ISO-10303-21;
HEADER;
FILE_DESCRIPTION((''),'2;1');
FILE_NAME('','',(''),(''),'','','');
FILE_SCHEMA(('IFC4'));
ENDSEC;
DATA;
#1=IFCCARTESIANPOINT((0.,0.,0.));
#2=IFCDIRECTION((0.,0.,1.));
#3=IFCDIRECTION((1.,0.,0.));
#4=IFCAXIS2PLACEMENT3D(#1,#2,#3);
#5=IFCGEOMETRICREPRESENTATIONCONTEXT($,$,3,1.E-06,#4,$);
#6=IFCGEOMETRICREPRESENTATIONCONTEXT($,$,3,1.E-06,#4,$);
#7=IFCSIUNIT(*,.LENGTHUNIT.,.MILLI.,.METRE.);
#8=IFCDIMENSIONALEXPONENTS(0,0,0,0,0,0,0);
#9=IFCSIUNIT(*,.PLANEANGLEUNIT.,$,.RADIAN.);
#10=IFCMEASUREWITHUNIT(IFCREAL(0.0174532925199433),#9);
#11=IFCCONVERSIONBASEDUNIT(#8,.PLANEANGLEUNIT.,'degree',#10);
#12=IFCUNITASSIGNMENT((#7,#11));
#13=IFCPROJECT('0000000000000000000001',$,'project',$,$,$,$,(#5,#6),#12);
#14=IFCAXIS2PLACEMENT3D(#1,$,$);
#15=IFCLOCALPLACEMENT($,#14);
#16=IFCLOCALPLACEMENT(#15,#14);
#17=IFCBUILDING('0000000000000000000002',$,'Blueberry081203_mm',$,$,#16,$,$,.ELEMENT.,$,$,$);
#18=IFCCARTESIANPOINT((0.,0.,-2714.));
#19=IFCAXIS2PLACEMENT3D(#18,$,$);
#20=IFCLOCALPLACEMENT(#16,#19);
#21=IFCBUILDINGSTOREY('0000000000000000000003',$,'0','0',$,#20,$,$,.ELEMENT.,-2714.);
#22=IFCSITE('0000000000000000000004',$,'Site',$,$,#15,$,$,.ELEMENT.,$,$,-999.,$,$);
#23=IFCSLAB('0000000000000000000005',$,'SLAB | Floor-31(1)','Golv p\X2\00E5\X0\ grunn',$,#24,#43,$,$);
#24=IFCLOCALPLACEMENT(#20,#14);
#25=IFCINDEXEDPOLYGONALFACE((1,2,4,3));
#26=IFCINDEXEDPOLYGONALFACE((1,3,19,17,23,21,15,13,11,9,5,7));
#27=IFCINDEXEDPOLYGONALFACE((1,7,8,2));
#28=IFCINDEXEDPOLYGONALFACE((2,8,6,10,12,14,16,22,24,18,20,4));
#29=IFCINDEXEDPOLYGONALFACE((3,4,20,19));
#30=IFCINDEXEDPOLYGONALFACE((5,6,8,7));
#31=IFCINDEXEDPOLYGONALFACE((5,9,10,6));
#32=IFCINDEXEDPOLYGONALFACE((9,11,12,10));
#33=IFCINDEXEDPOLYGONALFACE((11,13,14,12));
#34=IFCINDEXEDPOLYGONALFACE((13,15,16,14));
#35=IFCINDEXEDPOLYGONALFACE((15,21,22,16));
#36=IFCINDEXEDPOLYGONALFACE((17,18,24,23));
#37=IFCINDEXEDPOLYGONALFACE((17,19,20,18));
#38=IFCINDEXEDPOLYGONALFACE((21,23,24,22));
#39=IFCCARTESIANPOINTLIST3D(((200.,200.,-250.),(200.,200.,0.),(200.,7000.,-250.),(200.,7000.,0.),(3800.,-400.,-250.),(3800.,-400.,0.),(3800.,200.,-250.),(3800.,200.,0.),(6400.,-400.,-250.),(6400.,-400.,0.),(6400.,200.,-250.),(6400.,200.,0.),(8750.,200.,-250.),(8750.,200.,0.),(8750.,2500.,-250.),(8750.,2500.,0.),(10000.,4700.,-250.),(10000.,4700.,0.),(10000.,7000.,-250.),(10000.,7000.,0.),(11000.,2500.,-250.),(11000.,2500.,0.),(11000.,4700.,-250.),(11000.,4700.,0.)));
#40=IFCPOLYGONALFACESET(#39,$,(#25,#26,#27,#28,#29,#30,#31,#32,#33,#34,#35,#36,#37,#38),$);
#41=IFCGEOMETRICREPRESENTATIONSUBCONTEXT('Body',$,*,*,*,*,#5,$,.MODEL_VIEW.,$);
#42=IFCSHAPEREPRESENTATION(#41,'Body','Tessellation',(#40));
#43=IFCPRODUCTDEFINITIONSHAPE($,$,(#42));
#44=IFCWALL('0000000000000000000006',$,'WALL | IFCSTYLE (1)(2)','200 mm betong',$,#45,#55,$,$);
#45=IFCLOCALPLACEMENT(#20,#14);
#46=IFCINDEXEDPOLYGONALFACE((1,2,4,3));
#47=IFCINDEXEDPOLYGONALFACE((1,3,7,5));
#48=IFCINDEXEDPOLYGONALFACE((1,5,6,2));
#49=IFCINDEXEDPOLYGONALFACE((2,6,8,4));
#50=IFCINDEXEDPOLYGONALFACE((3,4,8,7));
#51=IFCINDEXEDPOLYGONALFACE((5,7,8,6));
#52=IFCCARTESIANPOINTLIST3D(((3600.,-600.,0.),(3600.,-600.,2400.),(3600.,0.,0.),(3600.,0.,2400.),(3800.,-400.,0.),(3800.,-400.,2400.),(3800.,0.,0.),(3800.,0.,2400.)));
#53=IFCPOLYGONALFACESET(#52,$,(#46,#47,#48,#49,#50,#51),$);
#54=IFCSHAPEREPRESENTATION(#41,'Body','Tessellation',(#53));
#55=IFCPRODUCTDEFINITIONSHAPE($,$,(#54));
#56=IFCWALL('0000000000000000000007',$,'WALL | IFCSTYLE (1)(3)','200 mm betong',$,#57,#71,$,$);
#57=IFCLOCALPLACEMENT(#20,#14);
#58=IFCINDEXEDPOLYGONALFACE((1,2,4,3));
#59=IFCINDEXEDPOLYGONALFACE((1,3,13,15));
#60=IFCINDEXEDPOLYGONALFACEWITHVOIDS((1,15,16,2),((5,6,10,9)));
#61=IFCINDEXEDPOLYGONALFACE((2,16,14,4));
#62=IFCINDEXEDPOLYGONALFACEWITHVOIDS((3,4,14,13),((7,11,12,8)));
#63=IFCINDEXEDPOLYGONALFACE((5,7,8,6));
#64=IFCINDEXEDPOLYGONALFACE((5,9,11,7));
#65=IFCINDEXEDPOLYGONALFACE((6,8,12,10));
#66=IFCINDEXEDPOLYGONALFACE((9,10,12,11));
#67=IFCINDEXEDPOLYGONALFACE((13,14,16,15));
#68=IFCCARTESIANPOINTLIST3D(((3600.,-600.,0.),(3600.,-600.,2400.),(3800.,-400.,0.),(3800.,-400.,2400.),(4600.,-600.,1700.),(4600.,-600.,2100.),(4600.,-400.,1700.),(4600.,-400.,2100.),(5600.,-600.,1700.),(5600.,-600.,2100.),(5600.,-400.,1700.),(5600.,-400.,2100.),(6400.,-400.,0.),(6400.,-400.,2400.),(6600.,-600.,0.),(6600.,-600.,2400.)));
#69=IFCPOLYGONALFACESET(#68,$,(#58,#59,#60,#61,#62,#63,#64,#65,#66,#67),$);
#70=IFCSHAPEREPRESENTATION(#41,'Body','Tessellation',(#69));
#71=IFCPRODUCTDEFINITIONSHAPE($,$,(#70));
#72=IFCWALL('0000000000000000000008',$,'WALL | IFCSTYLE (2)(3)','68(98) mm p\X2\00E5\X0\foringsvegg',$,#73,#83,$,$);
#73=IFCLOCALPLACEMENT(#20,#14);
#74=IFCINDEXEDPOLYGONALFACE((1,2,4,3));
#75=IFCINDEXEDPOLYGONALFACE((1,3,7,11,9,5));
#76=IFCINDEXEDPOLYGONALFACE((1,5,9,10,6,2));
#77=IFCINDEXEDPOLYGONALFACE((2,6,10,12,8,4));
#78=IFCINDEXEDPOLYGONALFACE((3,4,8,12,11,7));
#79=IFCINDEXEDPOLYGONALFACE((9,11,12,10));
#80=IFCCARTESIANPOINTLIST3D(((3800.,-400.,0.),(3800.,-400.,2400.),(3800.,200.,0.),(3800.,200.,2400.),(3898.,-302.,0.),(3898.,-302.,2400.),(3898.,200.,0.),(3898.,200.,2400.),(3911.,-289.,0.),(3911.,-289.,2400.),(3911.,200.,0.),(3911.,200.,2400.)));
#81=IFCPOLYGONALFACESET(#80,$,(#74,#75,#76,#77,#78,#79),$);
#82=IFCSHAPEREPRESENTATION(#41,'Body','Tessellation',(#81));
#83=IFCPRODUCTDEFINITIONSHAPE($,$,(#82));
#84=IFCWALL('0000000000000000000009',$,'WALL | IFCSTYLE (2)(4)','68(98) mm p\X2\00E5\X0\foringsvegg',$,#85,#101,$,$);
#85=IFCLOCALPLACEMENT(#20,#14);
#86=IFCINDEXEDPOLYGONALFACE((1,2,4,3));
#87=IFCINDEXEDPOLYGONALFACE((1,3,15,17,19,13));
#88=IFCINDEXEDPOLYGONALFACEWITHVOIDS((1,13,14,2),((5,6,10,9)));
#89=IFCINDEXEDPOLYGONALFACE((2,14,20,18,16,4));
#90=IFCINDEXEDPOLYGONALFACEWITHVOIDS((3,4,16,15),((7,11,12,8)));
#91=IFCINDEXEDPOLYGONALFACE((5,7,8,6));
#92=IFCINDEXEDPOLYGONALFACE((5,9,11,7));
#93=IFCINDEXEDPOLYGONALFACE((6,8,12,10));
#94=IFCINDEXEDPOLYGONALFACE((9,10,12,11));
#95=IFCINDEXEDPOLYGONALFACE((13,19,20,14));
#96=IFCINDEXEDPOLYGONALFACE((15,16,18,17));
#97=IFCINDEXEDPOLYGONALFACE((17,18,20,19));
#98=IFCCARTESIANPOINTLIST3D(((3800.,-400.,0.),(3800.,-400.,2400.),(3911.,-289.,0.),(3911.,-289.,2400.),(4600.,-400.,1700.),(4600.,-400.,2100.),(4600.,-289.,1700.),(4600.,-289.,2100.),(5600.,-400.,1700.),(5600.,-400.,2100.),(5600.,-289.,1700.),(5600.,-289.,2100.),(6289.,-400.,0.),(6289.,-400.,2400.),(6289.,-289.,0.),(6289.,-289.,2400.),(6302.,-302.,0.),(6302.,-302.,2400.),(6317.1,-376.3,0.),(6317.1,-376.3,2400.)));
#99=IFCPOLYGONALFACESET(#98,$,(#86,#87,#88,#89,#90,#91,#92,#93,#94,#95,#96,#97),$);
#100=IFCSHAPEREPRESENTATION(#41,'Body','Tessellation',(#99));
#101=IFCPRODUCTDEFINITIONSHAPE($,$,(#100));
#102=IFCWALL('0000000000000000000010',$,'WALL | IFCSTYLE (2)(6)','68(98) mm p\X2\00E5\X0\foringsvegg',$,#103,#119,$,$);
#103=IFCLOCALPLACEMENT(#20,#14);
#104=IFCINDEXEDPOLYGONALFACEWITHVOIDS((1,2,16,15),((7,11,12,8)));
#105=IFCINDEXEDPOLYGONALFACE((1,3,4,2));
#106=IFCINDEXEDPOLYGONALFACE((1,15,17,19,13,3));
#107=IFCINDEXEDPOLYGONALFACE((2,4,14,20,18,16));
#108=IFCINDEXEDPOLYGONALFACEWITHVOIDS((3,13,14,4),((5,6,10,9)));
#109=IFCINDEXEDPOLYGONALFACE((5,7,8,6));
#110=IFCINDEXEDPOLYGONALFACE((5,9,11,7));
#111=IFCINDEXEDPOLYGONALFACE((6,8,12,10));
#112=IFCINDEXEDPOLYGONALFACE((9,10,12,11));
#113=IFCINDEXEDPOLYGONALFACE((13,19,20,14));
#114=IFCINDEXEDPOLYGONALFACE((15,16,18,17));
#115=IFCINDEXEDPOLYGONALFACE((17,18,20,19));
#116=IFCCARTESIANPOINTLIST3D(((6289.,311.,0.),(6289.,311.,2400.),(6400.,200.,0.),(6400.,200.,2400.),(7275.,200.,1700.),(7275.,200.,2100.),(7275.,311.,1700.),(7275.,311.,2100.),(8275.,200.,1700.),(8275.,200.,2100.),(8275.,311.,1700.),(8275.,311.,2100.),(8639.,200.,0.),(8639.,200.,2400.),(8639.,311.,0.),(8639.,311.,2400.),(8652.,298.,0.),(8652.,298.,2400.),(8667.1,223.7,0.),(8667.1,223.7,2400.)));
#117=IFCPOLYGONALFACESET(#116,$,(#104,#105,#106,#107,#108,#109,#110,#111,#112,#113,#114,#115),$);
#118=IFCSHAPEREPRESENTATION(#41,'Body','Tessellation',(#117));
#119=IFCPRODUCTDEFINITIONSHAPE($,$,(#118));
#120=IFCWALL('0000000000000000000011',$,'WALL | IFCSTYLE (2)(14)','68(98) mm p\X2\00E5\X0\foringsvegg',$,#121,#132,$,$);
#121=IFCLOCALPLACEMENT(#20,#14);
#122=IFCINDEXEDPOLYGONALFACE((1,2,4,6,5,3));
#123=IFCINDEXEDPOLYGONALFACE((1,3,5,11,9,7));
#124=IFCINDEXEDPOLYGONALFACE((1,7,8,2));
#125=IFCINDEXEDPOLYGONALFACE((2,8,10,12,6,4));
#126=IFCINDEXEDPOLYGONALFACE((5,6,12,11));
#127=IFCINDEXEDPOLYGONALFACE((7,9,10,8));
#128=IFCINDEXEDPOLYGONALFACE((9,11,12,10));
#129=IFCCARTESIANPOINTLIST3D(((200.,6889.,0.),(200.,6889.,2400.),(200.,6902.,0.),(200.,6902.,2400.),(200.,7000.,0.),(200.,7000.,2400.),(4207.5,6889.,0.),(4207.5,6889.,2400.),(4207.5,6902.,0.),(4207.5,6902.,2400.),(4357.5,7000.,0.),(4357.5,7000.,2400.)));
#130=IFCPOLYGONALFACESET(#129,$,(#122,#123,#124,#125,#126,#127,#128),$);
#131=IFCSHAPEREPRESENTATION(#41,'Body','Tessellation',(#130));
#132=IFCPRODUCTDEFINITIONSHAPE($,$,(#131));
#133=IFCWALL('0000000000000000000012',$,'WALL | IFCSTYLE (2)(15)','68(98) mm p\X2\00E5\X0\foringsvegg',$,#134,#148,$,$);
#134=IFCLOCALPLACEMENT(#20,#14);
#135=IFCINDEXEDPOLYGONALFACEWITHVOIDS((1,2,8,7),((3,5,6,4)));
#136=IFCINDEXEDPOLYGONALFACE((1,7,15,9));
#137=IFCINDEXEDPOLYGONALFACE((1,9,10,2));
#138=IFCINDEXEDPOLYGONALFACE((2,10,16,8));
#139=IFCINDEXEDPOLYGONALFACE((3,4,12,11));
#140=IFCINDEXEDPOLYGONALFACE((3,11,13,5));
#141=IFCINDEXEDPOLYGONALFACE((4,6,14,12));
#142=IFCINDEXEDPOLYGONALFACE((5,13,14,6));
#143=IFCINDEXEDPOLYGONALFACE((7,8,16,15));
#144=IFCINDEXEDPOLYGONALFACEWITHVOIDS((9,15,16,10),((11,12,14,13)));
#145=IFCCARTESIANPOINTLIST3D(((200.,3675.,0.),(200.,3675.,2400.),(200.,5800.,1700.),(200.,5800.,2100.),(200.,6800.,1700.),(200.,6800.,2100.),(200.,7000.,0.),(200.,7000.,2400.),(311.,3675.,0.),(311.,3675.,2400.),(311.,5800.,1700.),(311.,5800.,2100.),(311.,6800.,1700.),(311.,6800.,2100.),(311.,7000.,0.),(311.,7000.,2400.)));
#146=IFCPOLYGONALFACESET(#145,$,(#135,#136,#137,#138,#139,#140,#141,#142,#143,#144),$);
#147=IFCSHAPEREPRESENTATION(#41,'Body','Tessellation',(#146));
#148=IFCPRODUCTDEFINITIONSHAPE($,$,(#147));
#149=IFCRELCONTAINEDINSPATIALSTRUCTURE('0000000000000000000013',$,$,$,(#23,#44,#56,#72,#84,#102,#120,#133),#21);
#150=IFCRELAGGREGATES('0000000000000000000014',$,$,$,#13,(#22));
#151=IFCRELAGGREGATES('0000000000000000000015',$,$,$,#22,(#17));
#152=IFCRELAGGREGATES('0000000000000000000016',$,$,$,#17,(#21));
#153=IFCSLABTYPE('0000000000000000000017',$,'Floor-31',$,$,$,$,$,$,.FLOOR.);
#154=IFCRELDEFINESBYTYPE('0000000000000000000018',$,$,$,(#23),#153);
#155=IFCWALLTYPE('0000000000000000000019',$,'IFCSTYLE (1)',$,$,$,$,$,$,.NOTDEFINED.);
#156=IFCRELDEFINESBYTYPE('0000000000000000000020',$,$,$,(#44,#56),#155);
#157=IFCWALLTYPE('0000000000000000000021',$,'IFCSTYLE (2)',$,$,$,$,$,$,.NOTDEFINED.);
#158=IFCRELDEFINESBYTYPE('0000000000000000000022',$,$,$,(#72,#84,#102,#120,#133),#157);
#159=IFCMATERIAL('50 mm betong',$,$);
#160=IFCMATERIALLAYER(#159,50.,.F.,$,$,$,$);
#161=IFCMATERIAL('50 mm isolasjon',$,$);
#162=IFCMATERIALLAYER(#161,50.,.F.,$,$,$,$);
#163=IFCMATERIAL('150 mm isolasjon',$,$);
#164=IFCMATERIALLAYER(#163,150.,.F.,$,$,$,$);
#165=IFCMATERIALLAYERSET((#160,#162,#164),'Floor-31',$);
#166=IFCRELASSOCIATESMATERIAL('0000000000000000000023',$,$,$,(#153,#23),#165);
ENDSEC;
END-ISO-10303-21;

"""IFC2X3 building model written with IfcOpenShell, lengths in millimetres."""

from ifc_helpers import new_model, entity, si_unit, converted_unit, frame, origin, origin_with_axes, origin_2d_with_axis, place, context, subcontext, project, spatial, polyline, segment, composite_curve, rectangle, outline, extrude, material, layer, layer_set, layer_usage, type_object, element, save


model = new_model("IFC2X3")

# Units and contexts
context_of_model_1 = context(None, 3, precision=1e-06, world=origin_with_axes())
context_of_model_2 = context(None, 3, precision=1e-06, world=origin_with_axes())
body_context = subcontext(context_of_model_1, "Body", None, "MODEL_VIEW")
ifc_project = project(units=[si_unit("LENGTHUNIT", "METRE", prefix="MILLI"), converted_unit("PLANEANGLEUNIT", "degree", entity("IfcReal", 0.0174532925199433), si_unit("PLANEANGLEUNIT", "RADIAN"), dimensions=[0, 0, 0, 0, 0, 0, 0])], contexts=[context_of_model_1, context_of_model_2])

# Site, building, storey
site_placement = place(None, origin())
site = spatial("IfcSite", under=ifc_project, at=site_placement, Name="Site", CompositionType="ELEMENT", RefElevation=-999.0)
building_placement = place(site_placement, origin())
building = spatial("IfcBuilding", under=site, at=building_placement, Name="Blueberry081203_mm", CompositionType="ELEMENT")
storey_placement = place(building_placement, frame((0.0, 0.0, -2714.0)))
storey = spatial("IfcBuildingStorey", under=building, at=storey_placement, Name="0", Description="0", CompositionType="ELEMENT", Elevation=-2714.0)

# Slab
ifc_material_1 = material(Name="50 mm betong")
ifc_layer_1 = layer(ifc_material_1, 50.0, ventilated=False)
ifc_material_2 = material(Name="50 mm isolasjon")
ifc_layer_2 = layer(ifc_material_2, 50.0, ventilated=False)
ifc_material_3 = material(Name="150 mm isolasjon")
ifc_layer_3 = layer(ifc_material_3, 150.0, ventilated=False)
ifc_layer_set_1 = layer_set([ifc_layer_1, ifc_layer_2, ifc_layer_3], Name="Floor-31")
ifc_layer_usage_1 = layer_usage(ifc_layer_set_1, "AXIS3", "POSITIVE", 0.0)
slab_type = type_object("IfcSlabType", Name="Floor-31", PredefinedType="FLOOR", material=ifc_layer_set_1)
slab_placement = place(storey_placement, frame((200.0, 200.0, -250.0), z_axis=(0.0, 0.0, -1.0), x_axis=(1.0, 0.0, 0.0)))
element("IfcSlab", 1, at=slab_placement, inside=storey, type_object=slab_type, material=ifc_layer_usage_1, Name="SLAB | Floor-31(1)", Description="Golv på grunn", context=body_context, shape_type="SweptSolid", held_by="IfcProductRepresentation", body=[
    extrude(outline(composite_curve([segment(polyline([(0.0, 0.0), (0.0, -6800.0)]), True, "CONTINUOUS"), segment(polyline([(0.0, -6800.0), (9800.0, -6800.0)]), True, "CONTINUOUS"), segment(polyline([(9800.0, -6800.0), (9800.0, -4500.0)]), True, "CONTINUOUS"), segment(polyline([(9800.0, -4500.0), (10800.0, -4500.0)]), True, "CONTINUOUS"), segment(polyline([(10800.0, -4500.0), (10800.0, -2300.0)]), True, "CONTINUOUS"), segment(polyline([(10800.0, -2300.0), (8550.0, -2300.0)]), True, "CONTINUOUS"), segment(polyline([(8550.0, -2300.0), (8550.0, 0.0)]), True, "CONTINUOUS"), segment(polyline([(8550.0, 0.0), (6200.0, 0.0)]), True, "CONTINUOUS"), segment(polyline([(6200.0, 0.0), (6200.0, 600.0)]), True, "CONTINUOUS"), segment(polyline([(6200.0, 600.0), (3600.0, 600.0)]), True, "CONTINUOUS"), segment(polyline([(3600.0, 600.0), (3600.0, 0.0)]), True, "CONTINUOUS"), segment(polyline([(3600.0, 0.0), (0.0, 0.0)]), True, "CONTINUOUS")], self_intersect=False)), frame((0.0, 0.0, -250.0)), (0.0, 0.0, 1.0), 250.0),
])

# Wall
wall_type_1 = type_object("IfcWallType", Name="IFCSTYLE (1)", PredefinedType="NOTDEFINED")
wall_1_placement = place(storey_placement, frame((3600.0, 0.0, 0.0), z_axis=(0.0, 0.0, 1.0), x_axis=(0.0, -1.0, 0.0)))
element("IfcWall", 2, at=wall_1_placement, inside=storey, type_object=wall_type_1, Name="WALL | IFCSTYLE (1)(2)", Description="200 mm betong", context=body_context, shape_type="SweptSolid", held_by="IfcProductRepresentation", body=[
    extrude(outline(composite_curve([segment(polyline([(0.0, 200.0), (0.0, 0.0)]), True, "CONTINUOUS"), segment(polyline([(0.0, 0.0), (600.0, 0.0)]), True, "CONTINUOUS"), segment(polyline([(600.0, 0.0), (400.0, 200.0)]), True, "CONTINUOUS"), segment(polyline([(400.0, 200.0), (0.0, 200.0)]), True, "CONTINUOUS")], self_intersect=False)), origin(), (0.0, 0.0, 1.0), 2400.0),
])

# Wall, opening
wall_2_placement = place(storey_placement, frame((3600.0, -600.0, 0.0)))
wall_2 = element("IfcWall", 3, at=wall_2_placement, inside=storey, type_object=wall_type_1, Name="WALL | IFCSTYLE (1)(3)", Description="200 mm betong", context=body_context, shape_type="SweptSolid", held_by="IfcProductRepresentation", body=[
    extrude(outline(composite_curve([segment(polyline([(200.0, 200.0), (0.0, 0.0)]), True, "CONTINUOUS"), segment(polyline([(0.0, 0.0), (3000.0, 0.0)]), True, "CONTINUOUS"), segment(polyline([(3000.0, 0.0), (2800.0, 200.0)]), True, "CONTINUOUS"), segment(polyline([(2800.0, 200.0), (200.0, 200.0)]), True, "CONTINUOUS")], self_intersect=False)), origin(), (0.0, 0.0, 1.0), 2400.0),
])
opening_1_placement = place(wall_2_placement, frame((1000.0, 100.0, 1700.0)))
element("IfcOpeningElement", 4, at=opening_1_placement, cuts=wall_2, context=body_context, shape_type="SweptSolid", held_by="IfcProductRepresentation", body=[
    extrude(rectangle(XDim=1000.0, YDim=400.0, at=origin_2d_with_axis()), frame((500.0, 100.0, 200.0), z_axis=(0.0, -1.0, 0.0), x_axis=(1.0, 0.0, 0.0)), (0.0, 0.0, 1.0), 200.0),
])

# Wall
wall_type_2 = type_object("IfcWallType", Name="IFCSTYLE (2)", PredefinedType="NOTDEFINED")
wall_3_placement = place(storey_placement, frame((3800.0, 200.0, 0.0), z_axis=(0.0, 0.0, 1.0), x_axis=(0.0, -1.0, 0.0)))
element("IfcWall", 5, at=wall_3_placement, inside=storey, type_object=wall_type_2, Name="WALL | IFCSTYLE (2)(3)", Description="68(98) mm påforingsvegg", context=body_context, shape_type="SweptSolid", held_by="IfcProductRepresentation", body=[
    extrude(outline(composite_curve([segment(polyline([(0.0, 98.0), (0.0, 0.0)]), True, "CONTINUOUS"), segment(polyline([(0.0, 0.0), (600.0, 0.0)]), True, "CONTINUOUS"), segment(polyline([(600.0, 0.0), (502.0, 98.0)]), True, "CONTINUOUS"), segment(polyline([(502.0, 98.0), (489.0, 111.0)]), True, "CONTINUOUS"), segment(polyline([(489.0, 111.0), (0.0, 111.0)]), True, "CONTINUOUS"), segment(polyline([(0.0, 111.0), (0.0, 98.0)]), True, "CONTINUOUS")], self_intersect=False)), origin(), (0.0, 0.0, 1.0), 2400.0),
])

# Walls, openings
wall_4_placement = place(storey_placement, frame((3800.0, -400.0, 0.0)))
wall_4 = element("IfcWall", 6, at=wall_4_placement, inside=storey, type_object=wall_type_2, Name="WALL | IFCSTYLE (2)(4)", Description="68(98) mm påforingsvegg", context=body_context, shape_type="SweptSolid", held_by="IfcProductRepresentation", body=[
    extrude(outline(composite_curve([segment(polyline([(98.0, 98.0), (0.0, 0.0)]), True, "CONTINUOUS"), segment(polyline([(0.0, 0.0), (2489.0, 0.0)]), True, "CONTINUOUS"), segment(polyline([(2489.0, 0.0), (2517.1, 23.7)]), True, "CONTINUOUS"), segment(polyline([(2517.1, 23.7), (2502.0, 98.0)]), True, "CONTINUOUS"), segment(polyline([(2502.0, 98.0), (2489.0, 111.0)]), True, "CONTINUOUS"), segment(polyline([(2489.0, 111.0), (111.0, 111.0)]), True, "CONTINUOUS"), segment(polyline([(111.0, 111.0), (98.0, 98.0)]), True, "CONTINUOUS")], self_intersect=False)), origin(), (0.0, 0.0, 1.0), 2400.0),
])
opening_2_placement = place(wall_4_placement, frame((800.0, 55.5, 1700.0)))
element("IfcOpeningElement", 7, at=opening_2_placement, cuts=wall_4, context=body_context, shape_type="SweptSolid", held_by="IfcProductRepresentation", body=[
    extrude(rectangle(XDim=1000.0, YDim=400.0, at=origin_2d_with_axis()), frame((500.0, 55.5, 200.0), z_axis=(0.0, -1.0, 0.0), x_axis=(1.0, 0.0, 0.0)), (0.0, 0.0, 1.0), 111.0),
])
wall_5_placement = place(storey_placement, frame((6400.0, 200.0, 0.0)))
wall_5 = element("IfcWall", 8, at=wall_5_placement, inside=storey, type_object=wall_type_2, Name="WALL | IFCSTYLE (2)(6)", Description="68(98) mm påforingsvegg", context=body_context, shape_type="SweptSolid", held_by="IfcProductRepresentation", body=[
    extrude(outline(composite_curve([segment(polyline([(-98.0, 98.0), (0.0, 0.0)]), True, "CONTINUOUS"), segment(polyline([(0.0, 0.0), (2239.0, 0.0)]), True, "CONTINUOUS"), segment(polyline([(2239.0, 0.0), (2267.1, 23.7)]), True, "CONTINUOUS"), segment(polyline([(2267.1, 23.7), (2252.0, 98.0)]), True, "CONTINUOUS"), segment(polyline([(2252.0, 98.0), (2239.0, 111.0)]), True, "CONTINUOUS"), segment(polyline([(2239.0, 111.0), (-111.0, 111.0)]), True, "CONTINUOUS"), segment(polyline([(-111.0, 111.0), (-98.0, 98.0)]), True, "CONTINUOUS")], self_intersect=False)), origin(), (0.0, 0.0, 1.0), 2400.0),
])
opening_3_placement = place(wall_5_placement, frame((875.0, 55.5, 1700.0)))
element("IfcOpeningElement", 9, at=opening_3_placement, cuts=wall_5, context=body_context, shape_type="SweptSolid", held_by="IfcProductRepresentation", body=[
    extrude(rectangle(XDim=1000.0, YDim=400.0, at=origin_2d_with_axis()), frame((500.0, 55.5, 200.0), z_axis=(0.0, -1.0, 0.0), x_axis=(1.0, 0.0, 0.0)), (0.0, 0.0, 1.0), 111.0),
])

# Wall
wall_6_placement = place(storey_placement, frame((4207.5, 7000.0, 0.0), z_axis=(0.0, 0.0, 1.0), x_axis=(-1.0, 0.0, 0.0)))
element("IfcWall", 10, at=wall_6_placement, inside=storey, type_object=wall_type_2, Name="WALL | IFCSTYLE (2)(14)", Description="68(98) mm påforingsvegg", context=body_context, shape_type="SweptSolid", held_by="IfcProductRepresentation", body=[
    extrude(outline(composite_curve([segment(polyline([(0.0, 98.0), (-150.0, 0.0)]), True, "CONTINUOUS"), segment(polyline([(-150.0, 0.0), (4007.5, 0.0)]), True, "CONTINUOUS"), segment(polyline([(4007.5, 0.0), (4007.5, 98.0)]), True, "CONTINUOUS"), segment(polyline([(4007.5, 98.0), (4007.5, 111.0)]), True, "CONTINUOUS"), segment(polyline([(4007.5, 111.0), (0.0, 111.0)]), True, "CONTINUOUS"), segment(polyline([(0.0, 111.0), (0.0, 98.0)]), True, "CONTINUOUS")], self_intersect=False)), origin(), (0.0, 0.0, 1.0), 2400.0),
])

# Wall, opening
wall_7_placement = place(storey_placement, frame((200.0, 7000.0, 0.0), z_axis=(0.0, 0.0, 1.0), x_axis=(0.0, -1.0, 0.0)))
wall_7 = element("IfcWall", 11, at=wall_7_placement, inside=storey, type_object=wall_type_2, Name="WALL | IFCSTYLE (2)(15)", Description="68(98) mm påforingsvegg", context=body_context, shape_type="SweptSolid", held_by="IfcProductRepresentation", body=[
    extrude(outline(composite_curve([segment(polyline([(0.0, 98.0), (0.0, 0.0)]), True, "CONTINUOUS"), segment(polyline([(0.0, 0.0), (3325.0, 0.0)]), True, "CONTINUOUS"), segment(polyline([(3325.0, 0.0), (3325.0, 98.0)]), True, "CONTINUOUS"), segment(polyline([(3325.0, 98.0), (3325.0, 111.0)]), True, "CONTINUOUS"), segment(polyline([(3325.0, 111.0), (0.0, 111.0)]), True, "CONTINUOUS"), segment(polyline([(0.0, 111.0), (0.0, 98.0)]), True, "CONTINUOUS")], self_intersect=False)), origin(), (0.0, 0.0, 1.0), 2400.0),
])
opening_4_placement = place(wall_7_placement, frame((200.0, 55.5, 1700.0)))
element("IfcOpeningElement", 12, at=opening_4_placement, cuts=wall_7, context=body_context, shape_type="SweptSolid", held_by="IfcProductRepresentation", body=[
    extrude(rectangle(XDim=1000.0, YDim=400.0, at=origin_2d_with_axis()), frame((500.0, 55.5, 200.0), z_axis=(0.0, -1.0, 0.0), x_axis=(1.0, 0.0, 0.0)), (0.0, 0.0, 1.0), 111.0),
])

save(model, "model.ifc")
